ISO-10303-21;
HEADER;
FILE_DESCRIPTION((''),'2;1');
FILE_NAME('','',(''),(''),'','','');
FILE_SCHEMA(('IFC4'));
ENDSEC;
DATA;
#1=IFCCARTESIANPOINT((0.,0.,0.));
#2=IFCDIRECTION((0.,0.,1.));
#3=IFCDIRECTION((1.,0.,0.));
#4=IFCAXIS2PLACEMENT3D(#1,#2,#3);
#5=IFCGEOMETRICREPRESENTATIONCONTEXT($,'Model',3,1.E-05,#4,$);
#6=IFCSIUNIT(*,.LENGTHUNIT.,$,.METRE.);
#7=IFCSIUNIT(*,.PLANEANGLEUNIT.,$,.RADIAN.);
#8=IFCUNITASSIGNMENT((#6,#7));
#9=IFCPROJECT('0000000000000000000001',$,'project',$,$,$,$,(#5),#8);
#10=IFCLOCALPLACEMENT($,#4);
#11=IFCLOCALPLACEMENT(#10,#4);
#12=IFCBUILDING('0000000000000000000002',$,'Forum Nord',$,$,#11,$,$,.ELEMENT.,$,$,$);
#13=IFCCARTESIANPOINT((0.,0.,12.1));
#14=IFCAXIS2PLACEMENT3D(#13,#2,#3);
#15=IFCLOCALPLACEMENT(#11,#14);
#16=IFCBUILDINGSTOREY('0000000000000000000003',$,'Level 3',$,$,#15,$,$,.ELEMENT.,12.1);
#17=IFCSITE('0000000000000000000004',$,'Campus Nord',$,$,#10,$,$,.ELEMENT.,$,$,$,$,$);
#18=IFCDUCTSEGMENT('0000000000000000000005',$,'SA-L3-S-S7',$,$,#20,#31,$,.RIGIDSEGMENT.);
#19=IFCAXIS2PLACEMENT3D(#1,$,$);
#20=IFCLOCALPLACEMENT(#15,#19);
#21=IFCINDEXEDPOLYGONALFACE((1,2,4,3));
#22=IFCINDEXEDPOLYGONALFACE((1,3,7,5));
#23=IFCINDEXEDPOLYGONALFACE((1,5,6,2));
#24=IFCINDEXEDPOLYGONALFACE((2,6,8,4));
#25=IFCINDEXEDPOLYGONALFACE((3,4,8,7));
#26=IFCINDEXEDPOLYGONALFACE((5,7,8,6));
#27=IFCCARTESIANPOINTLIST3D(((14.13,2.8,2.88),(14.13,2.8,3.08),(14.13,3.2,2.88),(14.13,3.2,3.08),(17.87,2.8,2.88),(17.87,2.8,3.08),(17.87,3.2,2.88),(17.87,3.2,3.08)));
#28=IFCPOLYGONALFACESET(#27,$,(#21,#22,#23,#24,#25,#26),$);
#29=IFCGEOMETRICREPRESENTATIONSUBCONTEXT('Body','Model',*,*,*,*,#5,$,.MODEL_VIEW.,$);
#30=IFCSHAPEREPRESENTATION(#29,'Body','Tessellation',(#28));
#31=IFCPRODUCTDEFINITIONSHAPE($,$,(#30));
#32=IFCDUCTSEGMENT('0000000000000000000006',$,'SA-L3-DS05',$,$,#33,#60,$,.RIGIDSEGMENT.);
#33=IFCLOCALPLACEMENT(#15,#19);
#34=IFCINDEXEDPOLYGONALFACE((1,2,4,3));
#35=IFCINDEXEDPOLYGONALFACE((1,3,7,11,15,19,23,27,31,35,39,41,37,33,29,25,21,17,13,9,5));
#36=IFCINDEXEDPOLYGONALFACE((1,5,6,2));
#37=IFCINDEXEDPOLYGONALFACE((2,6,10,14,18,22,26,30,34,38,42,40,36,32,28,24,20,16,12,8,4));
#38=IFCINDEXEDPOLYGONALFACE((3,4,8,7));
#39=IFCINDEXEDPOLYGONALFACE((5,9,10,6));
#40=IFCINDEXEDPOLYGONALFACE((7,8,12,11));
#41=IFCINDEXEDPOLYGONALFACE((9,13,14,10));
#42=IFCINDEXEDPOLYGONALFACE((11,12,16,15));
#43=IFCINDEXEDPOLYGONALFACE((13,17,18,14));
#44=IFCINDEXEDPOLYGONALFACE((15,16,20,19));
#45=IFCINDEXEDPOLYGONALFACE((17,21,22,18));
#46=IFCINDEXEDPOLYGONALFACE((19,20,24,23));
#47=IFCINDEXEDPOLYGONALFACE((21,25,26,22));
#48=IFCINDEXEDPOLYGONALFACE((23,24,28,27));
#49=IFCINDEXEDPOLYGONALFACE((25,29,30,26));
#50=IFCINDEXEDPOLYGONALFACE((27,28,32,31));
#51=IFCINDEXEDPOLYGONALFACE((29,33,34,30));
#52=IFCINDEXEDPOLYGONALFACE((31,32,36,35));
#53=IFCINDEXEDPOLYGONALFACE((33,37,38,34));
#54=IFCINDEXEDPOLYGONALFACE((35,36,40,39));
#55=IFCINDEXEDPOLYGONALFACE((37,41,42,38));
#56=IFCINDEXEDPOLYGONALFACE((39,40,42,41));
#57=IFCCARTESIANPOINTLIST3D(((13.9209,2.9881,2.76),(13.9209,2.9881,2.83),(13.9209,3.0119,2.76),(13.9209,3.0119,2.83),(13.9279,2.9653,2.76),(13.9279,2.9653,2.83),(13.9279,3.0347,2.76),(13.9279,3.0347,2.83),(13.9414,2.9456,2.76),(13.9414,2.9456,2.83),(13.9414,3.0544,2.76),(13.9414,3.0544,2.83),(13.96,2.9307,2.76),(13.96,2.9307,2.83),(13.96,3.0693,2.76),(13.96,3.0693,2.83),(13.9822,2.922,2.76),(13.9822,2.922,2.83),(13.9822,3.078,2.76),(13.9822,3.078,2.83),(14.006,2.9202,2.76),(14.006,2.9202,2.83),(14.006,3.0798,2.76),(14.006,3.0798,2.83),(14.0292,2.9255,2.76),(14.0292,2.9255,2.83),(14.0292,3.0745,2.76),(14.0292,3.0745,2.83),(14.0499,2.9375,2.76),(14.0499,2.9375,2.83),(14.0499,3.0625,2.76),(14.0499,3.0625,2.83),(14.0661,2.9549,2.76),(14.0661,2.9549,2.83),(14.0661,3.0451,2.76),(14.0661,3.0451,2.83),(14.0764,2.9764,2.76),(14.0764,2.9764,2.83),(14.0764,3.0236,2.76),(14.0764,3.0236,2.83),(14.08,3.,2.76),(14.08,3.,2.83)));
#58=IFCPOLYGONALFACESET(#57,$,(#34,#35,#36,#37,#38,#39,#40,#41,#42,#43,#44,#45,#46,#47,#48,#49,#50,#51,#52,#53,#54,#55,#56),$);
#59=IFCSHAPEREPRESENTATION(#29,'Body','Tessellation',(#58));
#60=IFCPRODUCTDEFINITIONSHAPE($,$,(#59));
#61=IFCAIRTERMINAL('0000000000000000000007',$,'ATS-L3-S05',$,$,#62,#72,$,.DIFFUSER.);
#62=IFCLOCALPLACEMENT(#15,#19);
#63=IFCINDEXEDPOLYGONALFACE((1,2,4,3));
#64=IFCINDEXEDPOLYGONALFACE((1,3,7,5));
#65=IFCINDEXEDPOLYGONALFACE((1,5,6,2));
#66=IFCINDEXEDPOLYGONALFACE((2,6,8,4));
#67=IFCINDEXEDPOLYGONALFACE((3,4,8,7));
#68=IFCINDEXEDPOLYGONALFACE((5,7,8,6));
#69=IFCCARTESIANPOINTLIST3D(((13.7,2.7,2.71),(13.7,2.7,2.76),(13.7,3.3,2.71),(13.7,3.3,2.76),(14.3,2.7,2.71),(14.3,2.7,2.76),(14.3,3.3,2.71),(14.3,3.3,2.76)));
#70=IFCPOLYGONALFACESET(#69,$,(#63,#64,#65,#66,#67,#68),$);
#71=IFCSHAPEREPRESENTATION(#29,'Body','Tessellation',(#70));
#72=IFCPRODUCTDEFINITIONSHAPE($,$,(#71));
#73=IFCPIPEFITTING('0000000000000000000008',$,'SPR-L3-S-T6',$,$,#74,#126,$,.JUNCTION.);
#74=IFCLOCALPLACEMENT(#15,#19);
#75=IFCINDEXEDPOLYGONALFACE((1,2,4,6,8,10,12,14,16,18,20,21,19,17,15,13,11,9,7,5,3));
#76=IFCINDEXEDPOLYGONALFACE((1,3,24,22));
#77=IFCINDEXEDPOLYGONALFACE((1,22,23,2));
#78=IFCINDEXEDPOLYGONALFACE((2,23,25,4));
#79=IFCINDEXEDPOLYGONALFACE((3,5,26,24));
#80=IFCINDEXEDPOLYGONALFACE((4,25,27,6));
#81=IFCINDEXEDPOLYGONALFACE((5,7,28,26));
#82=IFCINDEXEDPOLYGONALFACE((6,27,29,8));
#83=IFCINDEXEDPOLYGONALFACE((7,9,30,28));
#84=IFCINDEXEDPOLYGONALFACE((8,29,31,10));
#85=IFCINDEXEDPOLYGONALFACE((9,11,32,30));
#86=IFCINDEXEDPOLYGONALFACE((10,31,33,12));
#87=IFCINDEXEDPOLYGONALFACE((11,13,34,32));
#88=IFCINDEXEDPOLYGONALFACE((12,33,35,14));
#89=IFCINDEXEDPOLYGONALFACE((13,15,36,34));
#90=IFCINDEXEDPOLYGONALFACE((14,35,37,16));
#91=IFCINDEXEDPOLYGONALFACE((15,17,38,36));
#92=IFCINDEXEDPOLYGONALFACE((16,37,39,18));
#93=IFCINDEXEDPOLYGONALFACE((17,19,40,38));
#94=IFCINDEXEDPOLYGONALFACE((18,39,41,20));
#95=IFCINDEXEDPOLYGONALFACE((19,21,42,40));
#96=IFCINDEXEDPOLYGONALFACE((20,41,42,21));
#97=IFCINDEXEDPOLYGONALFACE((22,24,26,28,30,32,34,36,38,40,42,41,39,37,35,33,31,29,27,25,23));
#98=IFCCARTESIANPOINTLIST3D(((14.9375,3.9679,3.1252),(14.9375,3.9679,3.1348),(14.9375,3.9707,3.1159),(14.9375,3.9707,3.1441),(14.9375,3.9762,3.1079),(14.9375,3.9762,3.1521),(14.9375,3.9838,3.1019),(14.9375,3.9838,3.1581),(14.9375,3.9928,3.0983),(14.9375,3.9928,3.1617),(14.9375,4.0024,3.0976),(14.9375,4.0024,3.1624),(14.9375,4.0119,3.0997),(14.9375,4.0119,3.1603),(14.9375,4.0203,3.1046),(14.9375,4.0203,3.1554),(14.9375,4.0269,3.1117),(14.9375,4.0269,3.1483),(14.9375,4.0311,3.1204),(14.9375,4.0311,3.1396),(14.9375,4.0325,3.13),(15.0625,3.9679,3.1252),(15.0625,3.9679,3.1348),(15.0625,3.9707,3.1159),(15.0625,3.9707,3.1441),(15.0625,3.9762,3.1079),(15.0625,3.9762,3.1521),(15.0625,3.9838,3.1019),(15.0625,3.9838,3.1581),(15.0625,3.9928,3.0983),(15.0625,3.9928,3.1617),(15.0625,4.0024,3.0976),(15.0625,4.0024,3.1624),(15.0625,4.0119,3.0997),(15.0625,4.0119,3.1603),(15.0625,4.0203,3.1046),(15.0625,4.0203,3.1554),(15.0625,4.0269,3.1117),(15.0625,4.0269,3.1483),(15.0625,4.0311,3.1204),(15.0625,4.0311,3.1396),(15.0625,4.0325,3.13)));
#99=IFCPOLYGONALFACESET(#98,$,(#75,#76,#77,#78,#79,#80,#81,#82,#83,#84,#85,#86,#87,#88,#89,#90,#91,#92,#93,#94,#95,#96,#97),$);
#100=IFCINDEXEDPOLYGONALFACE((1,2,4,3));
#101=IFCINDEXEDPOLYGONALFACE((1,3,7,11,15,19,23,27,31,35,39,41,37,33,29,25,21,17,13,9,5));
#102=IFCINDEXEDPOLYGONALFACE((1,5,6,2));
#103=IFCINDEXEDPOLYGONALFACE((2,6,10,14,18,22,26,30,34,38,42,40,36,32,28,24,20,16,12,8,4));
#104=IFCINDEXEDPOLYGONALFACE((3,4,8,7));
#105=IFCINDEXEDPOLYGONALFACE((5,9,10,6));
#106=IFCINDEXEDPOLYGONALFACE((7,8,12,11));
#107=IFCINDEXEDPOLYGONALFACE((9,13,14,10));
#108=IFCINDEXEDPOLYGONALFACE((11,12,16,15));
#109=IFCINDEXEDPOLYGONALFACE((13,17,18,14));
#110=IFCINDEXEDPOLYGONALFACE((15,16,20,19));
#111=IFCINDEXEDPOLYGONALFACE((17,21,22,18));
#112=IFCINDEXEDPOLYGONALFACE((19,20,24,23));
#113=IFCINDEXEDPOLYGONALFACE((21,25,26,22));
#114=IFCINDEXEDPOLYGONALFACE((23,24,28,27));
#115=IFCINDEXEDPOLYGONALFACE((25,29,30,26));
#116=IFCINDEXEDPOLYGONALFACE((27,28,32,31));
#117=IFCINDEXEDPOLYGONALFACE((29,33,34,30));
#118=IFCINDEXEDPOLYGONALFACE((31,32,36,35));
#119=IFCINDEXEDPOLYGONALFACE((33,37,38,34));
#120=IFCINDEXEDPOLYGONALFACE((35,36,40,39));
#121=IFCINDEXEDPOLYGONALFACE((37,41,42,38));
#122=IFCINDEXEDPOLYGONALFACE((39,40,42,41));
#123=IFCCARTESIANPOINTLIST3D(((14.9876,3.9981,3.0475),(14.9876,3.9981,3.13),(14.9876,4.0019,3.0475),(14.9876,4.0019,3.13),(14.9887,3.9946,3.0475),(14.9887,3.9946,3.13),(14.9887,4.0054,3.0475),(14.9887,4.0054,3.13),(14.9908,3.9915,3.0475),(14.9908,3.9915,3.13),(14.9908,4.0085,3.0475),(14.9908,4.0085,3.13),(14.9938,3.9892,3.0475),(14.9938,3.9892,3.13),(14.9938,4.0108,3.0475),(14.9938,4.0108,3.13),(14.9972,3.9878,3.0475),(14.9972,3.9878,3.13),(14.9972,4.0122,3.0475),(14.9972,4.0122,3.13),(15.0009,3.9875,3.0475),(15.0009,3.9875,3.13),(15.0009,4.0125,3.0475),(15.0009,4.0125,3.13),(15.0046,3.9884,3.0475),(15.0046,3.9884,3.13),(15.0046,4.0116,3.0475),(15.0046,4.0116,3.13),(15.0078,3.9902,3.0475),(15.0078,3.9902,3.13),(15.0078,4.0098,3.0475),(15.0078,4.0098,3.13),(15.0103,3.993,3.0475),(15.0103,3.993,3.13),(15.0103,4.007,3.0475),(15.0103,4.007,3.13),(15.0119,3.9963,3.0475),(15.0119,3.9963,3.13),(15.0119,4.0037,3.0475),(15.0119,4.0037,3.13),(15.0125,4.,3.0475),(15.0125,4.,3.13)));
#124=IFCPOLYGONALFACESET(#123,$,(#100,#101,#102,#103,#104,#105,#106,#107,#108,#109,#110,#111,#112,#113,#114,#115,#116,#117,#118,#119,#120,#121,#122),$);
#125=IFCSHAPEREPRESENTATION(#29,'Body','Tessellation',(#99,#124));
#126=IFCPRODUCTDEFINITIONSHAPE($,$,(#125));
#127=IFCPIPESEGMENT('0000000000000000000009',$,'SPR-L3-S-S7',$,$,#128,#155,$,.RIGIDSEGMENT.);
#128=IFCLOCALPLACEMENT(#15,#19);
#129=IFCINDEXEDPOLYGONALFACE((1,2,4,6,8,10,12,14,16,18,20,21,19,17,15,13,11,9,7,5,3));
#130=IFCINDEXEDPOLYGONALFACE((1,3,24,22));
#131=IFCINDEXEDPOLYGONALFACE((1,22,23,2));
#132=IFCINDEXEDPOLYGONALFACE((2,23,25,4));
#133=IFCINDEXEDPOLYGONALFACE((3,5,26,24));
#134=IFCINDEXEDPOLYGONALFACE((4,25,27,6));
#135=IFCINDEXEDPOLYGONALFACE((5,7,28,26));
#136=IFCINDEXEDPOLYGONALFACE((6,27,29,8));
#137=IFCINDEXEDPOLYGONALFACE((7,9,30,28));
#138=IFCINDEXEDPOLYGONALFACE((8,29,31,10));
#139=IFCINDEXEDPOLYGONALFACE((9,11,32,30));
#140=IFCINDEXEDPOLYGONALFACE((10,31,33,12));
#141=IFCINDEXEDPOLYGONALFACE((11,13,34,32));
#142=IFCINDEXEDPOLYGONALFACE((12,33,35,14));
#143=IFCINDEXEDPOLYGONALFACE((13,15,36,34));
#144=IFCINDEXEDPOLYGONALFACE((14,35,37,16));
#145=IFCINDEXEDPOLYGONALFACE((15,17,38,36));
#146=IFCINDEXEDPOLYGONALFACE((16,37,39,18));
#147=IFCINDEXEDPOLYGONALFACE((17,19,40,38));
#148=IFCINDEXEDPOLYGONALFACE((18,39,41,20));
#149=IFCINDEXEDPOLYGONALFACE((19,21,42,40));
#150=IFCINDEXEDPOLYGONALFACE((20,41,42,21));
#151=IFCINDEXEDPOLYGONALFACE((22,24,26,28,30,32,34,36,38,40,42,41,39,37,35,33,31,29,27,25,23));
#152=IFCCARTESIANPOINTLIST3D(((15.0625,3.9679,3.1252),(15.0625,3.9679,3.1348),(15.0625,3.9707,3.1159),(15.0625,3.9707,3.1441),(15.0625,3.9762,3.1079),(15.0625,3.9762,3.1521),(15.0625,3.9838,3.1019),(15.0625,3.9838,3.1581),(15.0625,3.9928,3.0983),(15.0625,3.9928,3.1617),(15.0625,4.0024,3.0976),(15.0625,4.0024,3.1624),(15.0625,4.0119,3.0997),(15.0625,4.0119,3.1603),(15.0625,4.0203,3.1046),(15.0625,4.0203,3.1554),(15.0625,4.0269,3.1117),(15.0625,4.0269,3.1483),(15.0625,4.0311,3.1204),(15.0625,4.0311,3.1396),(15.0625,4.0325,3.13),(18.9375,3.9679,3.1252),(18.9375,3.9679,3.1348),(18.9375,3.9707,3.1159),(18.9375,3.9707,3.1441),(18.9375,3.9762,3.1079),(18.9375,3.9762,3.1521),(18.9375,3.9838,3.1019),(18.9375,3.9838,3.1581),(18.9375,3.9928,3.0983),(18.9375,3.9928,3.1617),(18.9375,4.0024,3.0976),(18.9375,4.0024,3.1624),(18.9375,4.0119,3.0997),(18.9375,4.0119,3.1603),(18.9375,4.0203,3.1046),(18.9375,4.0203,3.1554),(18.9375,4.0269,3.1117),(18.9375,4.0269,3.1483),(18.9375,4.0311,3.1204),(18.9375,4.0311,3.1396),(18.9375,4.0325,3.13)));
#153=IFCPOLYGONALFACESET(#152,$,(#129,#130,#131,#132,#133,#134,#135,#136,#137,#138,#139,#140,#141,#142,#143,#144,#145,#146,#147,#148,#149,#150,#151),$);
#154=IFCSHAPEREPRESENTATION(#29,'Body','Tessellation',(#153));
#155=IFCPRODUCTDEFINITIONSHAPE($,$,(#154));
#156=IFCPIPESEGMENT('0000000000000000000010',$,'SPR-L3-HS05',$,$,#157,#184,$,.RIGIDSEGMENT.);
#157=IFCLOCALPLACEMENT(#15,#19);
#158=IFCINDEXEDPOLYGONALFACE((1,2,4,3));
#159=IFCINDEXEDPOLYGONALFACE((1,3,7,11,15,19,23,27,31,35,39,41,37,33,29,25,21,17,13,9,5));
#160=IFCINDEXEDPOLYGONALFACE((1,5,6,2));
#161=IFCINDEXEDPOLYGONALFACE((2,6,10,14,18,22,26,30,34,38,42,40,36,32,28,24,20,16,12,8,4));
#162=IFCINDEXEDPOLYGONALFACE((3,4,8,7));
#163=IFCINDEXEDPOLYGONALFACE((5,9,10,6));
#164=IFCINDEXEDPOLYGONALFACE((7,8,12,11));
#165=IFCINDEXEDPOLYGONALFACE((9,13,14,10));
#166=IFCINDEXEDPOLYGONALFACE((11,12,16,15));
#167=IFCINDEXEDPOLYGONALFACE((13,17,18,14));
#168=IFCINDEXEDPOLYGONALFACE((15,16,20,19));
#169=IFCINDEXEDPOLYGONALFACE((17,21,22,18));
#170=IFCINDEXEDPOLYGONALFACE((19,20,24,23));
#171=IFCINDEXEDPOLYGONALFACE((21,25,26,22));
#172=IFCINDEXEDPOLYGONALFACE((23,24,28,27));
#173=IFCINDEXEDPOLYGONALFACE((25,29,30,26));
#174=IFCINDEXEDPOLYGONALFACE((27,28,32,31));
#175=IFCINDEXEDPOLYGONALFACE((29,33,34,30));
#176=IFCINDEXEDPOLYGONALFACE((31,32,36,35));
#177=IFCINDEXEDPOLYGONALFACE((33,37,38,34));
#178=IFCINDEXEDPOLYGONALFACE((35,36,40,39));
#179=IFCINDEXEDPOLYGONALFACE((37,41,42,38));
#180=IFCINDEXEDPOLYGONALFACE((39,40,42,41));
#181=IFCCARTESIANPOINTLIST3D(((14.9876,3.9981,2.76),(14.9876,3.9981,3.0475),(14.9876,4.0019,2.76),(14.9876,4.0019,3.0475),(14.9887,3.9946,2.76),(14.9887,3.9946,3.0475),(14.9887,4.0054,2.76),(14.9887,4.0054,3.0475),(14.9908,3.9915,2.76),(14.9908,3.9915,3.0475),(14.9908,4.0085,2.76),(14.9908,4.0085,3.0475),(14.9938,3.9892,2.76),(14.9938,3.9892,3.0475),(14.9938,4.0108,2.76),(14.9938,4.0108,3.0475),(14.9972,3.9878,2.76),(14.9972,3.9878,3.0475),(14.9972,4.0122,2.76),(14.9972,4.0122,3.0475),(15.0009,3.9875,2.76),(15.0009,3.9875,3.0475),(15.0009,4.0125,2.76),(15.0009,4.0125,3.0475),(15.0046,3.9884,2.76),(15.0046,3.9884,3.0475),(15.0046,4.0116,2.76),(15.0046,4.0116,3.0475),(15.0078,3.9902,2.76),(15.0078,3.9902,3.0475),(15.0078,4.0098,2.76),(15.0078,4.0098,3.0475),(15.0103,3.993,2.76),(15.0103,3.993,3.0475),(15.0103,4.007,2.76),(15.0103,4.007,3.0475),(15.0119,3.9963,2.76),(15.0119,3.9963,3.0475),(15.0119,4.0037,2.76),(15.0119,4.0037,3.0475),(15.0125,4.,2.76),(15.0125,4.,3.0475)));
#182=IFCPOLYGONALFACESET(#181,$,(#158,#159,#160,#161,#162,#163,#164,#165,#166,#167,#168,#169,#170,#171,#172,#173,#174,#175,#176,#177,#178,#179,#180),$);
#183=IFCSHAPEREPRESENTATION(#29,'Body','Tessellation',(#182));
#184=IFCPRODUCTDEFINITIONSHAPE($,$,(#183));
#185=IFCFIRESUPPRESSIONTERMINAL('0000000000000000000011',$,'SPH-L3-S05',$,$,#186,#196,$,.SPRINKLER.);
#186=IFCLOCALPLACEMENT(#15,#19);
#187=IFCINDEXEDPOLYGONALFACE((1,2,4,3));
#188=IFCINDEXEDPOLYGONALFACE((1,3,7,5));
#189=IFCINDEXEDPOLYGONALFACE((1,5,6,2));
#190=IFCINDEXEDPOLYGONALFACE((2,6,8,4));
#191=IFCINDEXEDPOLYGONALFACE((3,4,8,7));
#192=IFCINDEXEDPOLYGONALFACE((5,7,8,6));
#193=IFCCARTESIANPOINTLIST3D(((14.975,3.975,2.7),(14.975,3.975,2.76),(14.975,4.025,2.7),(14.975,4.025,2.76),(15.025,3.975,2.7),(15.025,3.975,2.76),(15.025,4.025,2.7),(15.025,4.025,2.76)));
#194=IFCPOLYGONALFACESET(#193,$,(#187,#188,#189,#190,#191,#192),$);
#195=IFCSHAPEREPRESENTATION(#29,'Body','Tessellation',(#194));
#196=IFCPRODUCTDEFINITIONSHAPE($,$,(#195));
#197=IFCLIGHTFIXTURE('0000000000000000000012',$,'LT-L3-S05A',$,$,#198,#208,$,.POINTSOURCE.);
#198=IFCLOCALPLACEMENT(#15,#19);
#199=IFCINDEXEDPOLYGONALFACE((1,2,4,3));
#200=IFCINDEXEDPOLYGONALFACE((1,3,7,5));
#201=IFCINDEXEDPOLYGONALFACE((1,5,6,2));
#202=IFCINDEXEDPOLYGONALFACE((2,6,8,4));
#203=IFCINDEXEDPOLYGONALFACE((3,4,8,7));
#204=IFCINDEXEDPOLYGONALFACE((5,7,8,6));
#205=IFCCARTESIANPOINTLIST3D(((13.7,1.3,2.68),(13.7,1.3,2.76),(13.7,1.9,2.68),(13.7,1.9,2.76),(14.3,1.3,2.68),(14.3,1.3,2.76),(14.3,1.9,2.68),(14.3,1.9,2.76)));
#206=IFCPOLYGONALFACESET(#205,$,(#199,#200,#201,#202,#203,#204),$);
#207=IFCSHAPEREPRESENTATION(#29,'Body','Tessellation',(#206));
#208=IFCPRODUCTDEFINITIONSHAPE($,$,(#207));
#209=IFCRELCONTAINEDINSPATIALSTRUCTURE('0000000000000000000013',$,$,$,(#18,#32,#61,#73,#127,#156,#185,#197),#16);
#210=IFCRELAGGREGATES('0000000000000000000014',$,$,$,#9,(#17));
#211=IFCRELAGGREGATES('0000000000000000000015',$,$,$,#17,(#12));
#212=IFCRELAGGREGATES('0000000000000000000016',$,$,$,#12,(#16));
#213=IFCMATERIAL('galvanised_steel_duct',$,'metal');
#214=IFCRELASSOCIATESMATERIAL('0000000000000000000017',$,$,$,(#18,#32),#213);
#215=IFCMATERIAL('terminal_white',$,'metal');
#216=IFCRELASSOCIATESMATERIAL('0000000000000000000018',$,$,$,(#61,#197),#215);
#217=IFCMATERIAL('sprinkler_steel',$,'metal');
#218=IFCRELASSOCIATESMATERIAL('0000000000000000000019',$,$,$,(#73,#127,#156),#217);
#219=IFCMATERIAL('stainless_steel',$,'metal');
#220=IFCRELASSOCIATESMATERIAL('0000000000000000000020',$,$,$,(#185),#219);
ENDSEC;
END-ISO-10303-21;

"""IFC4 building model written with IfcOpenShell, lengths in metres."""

from ifc_helpers import new_model, si_unit, frame, origin_with_axes, origin_2d_with_axis, place, context, subcontext, project, spatial, rectangle, circle, extrude, material, element, save


model = new_model("IFC4")

# Units and contexts
model_context = context("Model", 3, precision=1e-05, world=origin_with_axes())
body_context = subcontext(model_context, "Body", "Model", "MODEL_VIEW")
ifc_project = project(units=[si_unit("LENGTHUNIT", "METRE"), si_unit("PLANEANGLEUNIT", "RADIAN")], contexts=[model_context])

# Site, building, storey
site_placement = place(None, origin_with_axes())
site = spatial("IfcSite", under=ifc_project, at=site_placement, Name="Campus Nord", CompositionType="ELEMENT")
building_placement = place(site_placement, origin_with_axes())
building = spatial("IfcBuilding", under=site, at=building_placement, Name="Forum Nord", CompositionType="ELEMENT")
storey_placement = place(building_placement, frame((0.0, 0.0, 12.1), z_axis=(0.0, 0.0, 1.0), x_axis=(1.0, 0.0, 0.0)))
storey = spatial("IfcBuildingStorey", under=building, at=storey_placement, Name="Level 3", CompositionType="ELEMENT", Elevation=12.1)

# Duct segments
ifc_material_1 = material(Name="galvanised_steel_duct", Category="metal")
duct_segment_1_placement = place(storey_placement, frame((14.13, 3.0, 2.98), z_axis=(1.0, 0.0, 0.0), x_axis=(0.0, 1.0, 0.0)))
element("IfcDuctSegment", 1, at=duct_segment_1_placement, inside=storey, material=ifc_material_1, Name="SA-L3-S-S7", PredefinedType="RIGIDSEGMENT", context=body_context, shape_type="SweptSolid", body=[
    extrude(rectangle(XDim=0.4, YDim=0.2, at=origin_2d_with_axis()), origin_with_axes(), (0.0, 0.0, 1.0), 3.74),
])
duct_segment_2_placement = place(storey_placement, frame((14.0, 3.0, 2.83), z_axis=(0.0, 0.0, -1.0), x_axis=(1.0, 0.0, 0.0)))
element("IfcDuctSegment", 2, at=duct_segment_2_placement, inside=storey, material=ifc_material_1, Name="SA-L3-DS05", PredefinedType="RIGIDSEGMENT", context=body_context, shape_type="SweptSolid", body=[
    extrude(circle(Radius=0.08, at=origin_2d_with_axis()), origin_with_axes(), (0.0, 0.0, 1.0), 0.07),
])

# Air terminal
ifc_material_2 = material(Name="terminal_white", Category="metal")
air_terminal_placement = place(storey_placement, frame((14.0, 3.0, 2.71), z_axis=(0.0, 0.0, 1.0), x_axis=(1.0, 0.0, 0.0)))
element("IfcAirTerminal", 3, at=air_terminal_placement, inside=storey, material=ifc_material_2, Name="ATS-L3-S05", PredefinedType="DIFFUSER", context=body_context, shape_type="SweptSolid", body=[
    extrude(rectangle(XDim=0.6, YDim=0.6, at=origin_2d_with_axis()), origin_with_axes(), (0.0, 0.0, 1.0), 0.05),
])

# Pipe fitting
ifc_material_3 = material(Name="sprinkler_steel", Category="metal")
pipe_fitting_placement = place(storey_placement, frame((14.9375, 4.0, 3.13), z_axis=(1.0, 0.0, 0.0), x_axis=(0.0, 1.0, 0.0)))
element("IfcPipeFitting", 4, at=pipe_fitting_placement, inside=storey, material=ifc_material_3, Name="SPR-L3-S-T6", PredefinedType="JUNCTION", context=body_context, shape_type="SweptSolid", body=[
    extrude(circle(Radius=0.0325, at=origin_2d_with_axis()), origin_with_axes(), (0.0, 0.0, 1.0), 0.125),
    extrude(circle(Radius=0.0125, at=origin_2d_with_axis()), frame((0.0, 0.0, 0.0625), z_axis=(0.0, -1.0, 0.0), x_axis=(0.0, 0.0, 1.0)), (0.0, 0.0, 1.0), 0.0825),
])

# Pipe segments
pipe_segment_1_placement = place(storey_placement, frame((15.0625, 4.0, 3.13), z_axis=(1.0, 0.0, 0.0), x_axis=(0.0, 1.0, 0.0)))
element("IfcPipeSegment", 5, at=pipe_segment_1_placement, inside=storey, material=ifc_material_3, Name="SPR-L3-S-S7", PredefinedType="RIGIDSEGMENT", context=body_context, shape_type="SweptSolid", body=[
    extrude(circle(Radius=0.0325, at=origin_2d_with_axis()), origin_with_axes(), (0.0, 0.0, 1.0), 3.875),
])
pipe_segment_2_placement = place(storey_placement, frame((15.0, 4.0, 3.0475), z_axis=(0.0, 0.0, -1.0), x_axis=(1.0, 0.0, 0.0)))
element("IfcPipeSegment", 6, at=pipe_segment_2_placement, inside=storey, material=ifc_material_3, Name="SPR-L3-HS05", PredefinedType="RIGIDSEGMENT", context=body_context, shape_type="SweptSolid", body=[
    extrude(circle(Radius=0.0125, at=origin_2d_with_axis()), origin_with_axes(), (0.0, 0.0, 1.0), 0.2875),
])

# Fire suppression terminal
ifc_material_4 = material(Name="stainless_steel", Category="metal")
fire_suppression_terminal_placement = place(storey_placement, frame((15.0, 4.0, 2.7), z_axis=(0.0, 0.0, 1.0), x_axis=(1.0, 0.0, 0.0)))
element("IfcFireSuppressionTerminal", 7, at=fire_suppression_terminal_placement, inside=storey, material=ifc_material_4, Name="SPH-L3-S05", PredefinedType="SPRINKLER", context=body_context, shape_type="SweptSolid", body=[
    extrude(rectangle(XDim=0.05, YDim=0.05, at=origin_2d_with_axis()), origin_with_axes(), (0.0, 0.0, 1.0), 0.06),
])

# Light fixture
light_fixture_placement = place(storey_placement, frame((14.0, 1.6, 2.68), z_axis=(0.0, 0.0, 1.0), x_axis=(1.0, 0.0, 0.0)))
element("IfcLightFixture", 8, at=light_fixture_placement, inside=storey, material=ifc_material_2, Name="LT-L3-S05A", PredefinedType="POINTSOURCE", context=body_context, shape_type="SweptSolid", body=[
    extrude(rectangle(XDim=0.6, YDim=0.6, at=origin_2d_with_axis()), origin_with_axes(), (0.0, 0.0, 1.0), 0.08),
])

save(model, "model.ifc")
